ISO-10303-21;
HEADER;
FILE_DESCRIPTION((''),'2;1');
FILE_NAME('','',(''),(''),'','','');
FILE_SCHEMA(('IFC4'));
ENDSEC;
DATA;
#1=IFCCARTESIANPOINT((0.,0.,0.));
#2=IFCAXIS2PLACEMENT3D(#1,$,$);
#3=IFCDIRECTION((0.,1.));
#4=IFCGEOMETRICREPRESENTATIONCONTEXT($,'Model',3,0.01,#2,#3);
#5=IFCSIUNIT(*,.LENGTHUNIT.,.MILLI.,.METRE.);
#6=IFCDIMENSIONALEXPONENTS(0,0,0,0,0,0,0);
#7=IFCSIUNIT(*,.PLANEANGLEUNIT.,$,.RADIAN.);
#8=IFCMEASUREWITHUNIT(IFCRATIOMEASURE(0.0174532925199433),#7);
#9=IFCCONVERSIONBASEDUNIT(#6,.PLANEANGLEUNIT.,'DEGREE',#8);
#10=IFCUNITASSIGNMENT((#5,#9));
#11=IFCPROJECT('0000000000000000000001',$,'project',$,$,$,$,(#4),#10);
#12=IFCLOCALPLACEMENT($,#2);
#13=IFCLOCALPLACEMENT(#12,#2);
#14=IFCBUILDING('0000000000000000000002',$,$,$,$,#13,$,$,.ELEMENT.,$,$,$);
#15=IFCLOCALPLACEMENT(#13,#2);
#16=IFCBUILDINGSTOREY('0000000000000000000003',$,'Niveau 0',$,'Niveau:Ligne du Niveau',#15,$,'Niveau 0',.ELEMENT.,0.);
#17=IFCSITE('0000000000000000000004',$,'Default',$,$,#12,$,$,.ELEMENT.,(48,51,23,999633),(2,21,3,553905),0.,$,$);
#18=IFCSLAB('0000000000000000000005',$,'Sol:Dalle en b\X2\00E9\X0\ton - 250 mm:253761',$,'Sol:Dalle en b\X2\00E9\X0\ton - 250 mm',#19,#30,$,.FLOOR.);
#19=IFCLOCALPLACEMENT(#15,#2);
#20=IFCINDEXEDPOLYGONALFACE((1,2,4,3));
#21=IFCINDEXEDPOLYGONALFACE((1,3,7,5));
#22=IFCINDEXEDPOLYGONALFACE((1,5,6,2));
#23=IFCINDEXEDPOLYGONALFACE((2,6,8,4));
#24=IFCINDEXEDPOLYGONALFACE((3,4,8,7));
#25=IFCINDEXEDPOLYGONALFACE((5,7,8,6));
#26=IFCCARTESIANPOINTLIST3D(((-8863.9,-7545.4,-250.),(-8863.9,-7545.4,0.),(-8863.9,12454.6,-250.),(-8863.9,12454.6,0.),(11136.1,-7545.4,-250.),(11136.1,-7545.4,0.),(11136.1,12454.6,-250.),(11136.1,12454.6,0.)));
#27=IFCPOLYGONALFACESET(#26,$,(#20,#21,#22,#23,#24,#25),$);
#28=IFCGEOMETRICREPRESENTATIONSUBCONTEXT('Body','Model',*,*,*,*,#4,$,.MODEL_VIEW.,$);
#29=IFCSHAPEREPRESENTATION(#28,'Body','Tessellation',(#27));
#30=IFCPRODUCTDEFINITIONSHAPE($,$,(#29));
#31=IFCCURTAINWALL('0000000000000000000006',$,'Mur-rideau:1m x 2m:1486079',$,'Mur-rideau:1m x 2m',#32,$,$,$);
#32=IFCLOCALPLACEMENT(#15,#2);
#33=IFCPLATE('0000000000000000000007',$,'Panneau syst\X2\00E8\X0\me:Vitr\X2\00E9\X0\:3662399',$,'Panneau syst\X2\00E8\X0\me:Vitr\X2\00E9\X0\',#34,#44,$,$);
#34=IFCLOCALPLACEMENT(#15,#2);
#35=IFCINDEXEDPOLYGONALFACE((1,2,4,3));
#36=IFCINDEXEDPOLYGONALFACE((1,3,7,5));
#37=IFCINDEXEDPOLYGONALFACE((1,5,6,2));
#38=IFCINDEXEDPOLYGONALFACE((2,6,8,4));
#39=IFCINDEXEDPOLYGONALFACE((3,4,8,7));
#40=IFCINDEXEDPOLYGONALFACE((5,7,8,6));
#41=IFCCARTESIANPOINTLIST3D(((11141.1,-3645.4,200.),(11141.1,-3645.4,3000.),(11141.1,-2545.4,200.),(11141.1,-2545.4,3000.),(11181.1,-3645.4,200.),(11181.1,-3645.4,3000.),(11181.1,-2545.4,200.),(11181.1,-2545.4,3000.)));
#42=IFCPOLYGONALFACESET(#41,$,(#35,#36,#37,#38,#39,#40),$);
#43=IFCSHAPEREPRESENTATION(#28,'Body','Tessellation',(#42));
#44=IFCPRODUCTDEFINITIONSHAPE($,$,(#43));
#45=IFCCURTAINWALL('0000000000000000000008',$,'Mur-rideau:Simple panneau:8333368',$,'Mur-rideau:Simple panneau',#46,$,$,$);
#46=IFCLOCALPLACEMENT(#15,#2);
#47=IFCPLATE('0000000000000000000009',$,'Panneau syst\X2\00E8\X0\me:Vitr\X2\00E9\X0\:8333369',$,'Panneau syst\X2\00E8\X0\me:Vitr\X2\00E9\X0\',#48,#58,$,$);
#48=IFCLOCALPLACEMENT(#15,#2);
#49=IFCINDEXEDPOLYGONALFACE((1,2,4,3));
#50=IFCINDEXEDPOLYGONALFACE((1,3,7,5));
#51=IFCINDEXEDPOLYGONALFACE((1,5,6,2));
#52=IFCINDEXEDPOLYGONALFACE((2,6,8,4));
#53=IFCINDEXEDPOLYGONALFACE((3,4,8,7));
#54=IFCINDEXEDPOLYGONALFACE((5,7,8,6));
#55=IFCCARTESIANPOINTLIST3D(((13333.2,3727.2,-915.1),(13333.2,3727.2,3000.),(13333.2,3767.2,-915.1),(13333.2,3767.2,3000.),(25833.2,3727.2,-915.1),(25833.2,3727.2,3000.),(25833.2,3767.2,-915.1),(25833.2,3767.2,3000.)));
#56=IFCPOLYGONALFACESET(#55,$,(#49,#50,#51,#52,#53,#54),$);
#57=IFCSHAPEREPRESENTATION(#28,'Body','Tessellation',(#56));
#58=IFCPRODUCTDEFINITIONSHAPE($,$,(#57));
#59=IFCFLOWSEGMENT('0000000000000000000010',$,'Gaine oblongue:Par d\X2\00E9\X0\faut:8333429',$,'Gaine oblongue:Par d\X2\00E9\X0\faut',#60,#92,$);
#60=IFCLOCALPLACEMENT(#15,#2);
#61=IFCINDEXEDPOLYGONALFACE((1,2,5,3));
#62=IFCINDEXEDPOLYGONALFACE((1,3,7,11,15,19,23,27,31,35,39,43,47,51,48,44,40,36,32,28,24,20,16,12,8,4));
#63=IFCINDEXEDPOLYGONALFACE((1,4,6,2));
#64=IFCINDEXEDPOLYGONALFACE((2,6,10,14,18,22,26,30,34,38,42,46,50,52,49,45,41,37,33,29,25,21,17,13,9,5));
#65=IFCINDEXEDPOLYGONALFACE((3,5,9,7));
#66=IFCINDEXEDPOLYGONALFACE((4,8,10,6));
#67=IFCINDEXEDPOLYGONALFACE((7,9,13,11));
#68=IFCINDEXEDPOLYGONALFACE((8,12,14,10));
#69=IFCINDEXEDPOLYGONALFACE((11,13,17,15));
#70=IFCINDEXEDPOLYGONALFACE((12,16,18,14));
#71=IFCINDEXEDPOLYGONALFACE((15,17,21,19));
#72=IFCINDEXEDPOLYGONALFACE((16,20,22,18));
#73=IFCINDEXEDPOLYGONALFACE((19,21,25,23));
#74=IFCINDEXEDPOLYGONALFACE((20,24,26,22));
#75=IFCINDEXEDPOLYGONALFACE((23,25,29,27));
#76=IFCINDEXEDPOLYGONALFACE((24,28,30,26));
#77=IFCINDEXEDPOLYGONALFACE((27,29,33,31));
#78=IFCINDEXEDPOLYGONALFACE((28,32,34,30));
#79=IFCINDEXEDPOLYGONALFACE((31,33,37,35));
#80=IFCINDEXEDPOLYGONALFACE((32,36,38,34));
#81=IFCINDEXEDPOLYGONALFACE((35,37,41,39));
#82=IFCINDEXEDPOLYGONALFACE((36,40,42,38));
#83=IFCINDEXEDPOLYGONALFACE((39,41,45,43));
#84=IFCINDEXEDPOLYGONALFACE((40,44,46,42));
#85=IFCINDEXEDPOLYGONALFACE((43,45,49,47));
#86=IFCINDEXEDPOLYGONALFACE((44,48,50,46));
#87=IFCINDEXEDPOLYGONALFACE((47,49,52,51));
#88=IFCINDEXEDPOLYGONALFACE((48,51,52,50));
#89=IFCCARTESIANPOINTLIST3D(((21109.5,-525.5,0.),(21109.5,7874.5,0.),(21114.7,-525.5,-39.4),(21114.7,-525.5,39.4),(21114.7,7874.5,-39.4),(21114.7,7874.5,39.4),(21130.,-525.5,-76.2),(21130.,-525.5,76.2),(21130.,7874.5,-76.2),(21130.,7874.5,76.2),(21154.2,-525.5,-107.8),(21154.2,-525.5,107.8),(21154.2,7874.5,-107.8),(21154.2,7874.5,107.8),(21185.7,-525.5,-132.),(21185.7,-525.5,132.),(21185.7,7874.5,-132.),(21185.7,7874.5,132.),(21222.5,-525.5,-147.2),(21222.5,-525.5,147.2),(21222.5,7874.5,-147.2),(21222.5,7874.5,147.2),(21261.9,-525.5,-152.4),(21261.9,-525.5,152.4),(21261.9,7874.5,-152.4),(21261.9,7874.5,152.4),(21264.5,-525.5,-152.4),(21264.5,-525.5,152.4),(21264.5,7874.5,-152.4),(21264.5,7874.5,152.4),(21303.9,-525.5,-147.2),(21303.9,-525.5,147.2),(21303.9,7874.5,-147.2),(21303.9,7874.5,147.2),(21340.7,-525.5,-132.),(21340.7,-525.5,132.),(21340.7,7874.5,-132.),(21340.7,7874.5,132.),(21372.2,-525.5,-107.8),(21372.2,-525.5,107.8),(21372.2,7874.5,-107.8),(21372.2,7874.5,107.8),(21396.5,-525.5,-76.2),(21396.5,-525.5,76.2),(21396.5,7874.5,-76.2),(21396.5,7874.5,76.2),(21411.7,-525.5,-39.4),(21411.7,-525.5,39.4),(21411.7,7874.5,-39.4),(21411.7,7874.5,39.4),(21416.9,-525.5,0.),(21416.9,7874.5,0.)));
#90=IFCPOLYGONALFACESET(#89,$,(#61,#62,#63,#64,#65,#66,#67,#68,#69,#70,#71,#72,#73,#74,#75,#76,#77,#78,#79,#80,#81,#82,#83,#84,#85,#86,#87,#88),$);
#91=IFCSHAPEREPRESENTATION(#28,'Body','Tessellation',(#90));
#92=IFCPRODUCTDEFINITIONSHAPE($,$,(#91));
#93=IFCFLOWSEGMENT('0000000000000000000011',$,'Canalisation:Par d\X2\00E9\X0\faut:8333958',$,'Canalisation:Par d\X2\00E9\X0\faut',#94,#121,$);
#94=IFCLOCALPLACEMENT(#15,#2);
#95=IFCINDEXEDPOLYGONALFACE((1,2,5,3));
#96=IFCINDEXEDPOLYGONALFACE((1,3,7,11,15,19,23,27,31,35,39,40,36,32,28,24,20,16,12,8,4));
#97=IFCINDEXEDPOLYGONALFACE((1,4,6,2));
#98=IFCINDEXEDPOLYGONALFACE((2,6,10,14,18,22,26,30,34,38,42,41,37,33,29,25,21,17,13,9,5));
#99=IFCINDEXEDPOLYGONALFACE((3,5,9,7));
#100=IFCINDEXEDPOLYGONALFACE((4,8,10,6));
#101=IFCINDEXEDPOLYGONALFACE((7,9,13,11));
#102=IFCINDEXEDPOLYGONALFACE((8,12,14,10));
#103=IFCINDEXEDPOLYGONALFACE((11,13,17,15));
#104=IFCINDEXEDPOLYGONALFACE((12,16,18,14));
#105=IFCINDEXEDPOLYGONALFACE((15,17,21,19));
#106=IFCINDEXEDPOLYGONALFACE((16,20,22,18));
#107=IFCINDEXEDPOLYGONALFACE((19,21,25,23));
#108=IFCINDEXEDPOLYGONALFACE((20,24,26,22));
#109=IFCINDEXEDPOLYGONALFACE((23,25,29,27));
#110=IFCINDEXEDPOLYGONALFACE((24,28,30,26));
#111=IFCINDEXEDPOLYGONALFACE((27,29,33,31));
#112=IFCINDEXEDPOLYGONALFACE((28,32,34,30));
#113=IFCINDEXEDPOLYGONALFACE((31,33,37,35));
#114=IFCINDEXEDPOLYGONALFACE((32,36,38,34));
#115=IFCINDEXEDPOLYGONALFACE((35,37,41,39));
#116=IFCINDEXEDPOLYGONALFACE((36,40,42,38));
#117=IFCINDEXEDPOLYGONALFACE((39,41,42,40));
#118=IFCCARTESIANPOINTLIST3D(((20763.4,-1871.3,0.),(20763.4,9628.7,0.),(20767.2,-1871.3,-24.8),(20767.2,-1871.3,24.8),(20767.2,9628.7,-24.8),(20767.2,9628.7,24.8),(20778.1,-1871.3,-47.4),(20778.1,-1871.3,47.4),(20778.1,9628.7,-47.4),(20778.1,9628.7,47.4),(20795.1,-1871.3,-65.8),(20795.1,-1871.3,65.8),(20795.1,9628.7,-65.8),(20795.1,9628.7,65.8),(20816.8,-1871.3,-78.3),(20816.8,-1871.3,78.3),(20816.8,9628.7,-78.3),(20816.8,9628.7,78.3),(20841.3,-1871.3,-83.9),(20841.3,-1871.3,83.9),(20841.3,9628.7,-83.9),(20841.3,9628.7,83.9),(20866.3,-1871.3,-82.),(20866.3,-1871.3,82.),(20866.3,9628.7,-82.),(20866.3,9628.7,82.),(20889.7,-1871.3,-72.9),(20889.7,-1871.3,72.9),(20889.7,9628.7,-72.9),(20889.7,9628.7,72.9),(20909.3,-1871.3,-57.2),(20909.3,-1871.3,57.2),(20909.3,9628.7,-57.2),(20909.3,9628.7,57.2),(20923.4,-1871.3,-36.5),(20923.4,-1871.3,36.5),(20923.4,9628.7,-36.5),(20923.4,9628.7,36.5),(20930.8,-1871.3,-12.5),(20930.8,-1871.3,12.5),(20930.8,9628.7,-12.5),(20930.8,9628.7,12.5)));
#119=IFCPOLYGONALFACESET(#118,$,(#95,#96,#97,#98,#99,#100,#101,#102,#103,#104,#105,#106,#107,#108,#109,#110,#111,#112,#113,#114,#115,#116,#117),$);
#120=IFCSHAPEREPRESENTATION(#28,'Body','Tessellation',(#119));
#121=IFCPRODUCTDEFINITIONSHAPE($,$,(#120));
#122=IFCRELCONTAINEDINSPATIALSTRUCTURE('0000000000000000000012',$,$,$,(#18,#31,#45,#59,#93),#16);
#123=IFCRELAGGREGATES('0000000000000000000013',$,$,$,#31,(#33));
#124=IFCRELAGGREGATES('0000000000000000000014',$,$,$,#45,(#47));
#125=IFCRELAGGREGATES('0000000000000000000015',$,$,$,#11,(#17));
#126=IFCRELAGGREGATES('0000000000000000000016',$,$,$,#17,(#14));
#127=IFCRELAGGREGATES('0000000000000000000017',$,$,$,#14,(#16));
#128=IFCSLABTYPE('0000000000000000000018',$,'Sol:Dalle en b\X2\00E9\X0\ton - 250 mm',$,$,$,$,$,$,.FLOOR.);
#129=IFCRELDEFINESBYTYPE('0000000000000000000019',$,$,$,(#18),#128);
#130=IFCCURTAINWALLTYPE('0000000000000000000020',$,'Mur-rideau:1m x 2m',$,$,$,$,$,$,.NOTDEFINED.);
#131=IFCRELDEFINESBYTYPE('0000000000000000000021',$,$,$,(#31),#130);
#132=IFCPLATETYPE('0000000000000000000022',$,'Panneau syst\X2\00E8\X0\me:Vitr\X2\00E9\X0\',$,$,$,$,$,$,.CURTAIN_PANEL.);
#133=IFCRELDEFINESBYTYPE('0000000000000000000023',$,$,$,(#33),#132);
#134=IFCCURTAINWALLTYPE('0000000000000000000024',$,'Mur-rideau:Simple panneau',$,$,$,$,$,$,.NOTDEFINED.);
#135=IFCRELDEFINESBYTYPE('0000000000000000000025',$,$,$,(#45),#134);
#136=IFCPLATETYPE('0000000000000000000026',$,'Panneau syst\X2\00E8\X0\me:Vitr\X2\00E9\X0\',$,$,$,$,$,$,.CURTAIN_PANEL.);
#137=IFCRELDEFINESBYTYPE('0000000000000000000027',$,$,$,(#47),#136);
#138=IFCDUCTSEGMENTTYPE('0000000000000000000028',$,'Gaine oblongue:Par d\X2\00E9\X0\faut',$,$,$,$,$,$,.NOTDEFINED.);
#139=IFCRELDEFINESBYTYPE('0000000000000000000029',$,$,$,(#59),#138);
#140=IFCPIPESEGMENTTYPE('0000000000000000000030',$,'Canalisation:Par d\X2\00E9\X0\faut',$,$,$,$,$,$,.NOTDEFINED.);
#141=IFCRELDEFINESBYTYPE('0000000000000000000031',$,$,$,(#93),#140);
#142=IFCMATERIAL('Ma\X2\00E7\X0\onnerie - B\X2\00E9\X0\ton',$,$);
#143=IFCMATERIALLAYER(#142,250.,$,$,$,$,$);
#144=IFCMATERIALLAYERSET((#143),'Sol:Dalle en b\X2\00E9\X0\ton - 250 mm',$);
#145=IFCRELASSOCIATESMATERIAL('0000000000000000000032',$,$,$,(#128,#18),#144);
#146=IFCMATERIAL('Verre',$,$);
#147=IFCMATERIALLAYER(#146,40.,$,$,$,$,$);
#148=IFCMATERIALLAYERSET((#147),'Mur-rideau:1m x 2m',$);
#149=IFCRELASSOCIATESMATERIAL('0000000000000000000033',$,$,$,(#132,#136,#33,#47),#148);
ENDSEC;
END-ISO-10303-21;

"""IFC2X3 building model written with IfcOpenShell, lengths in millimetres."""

from ifc_helpers import new_model, entity, si_unit, converted_unit, direction, frame, frame_2d, origin, origin_2d_with_axis, place, context, subcontext, project, spatial, polyline, circle_curve, parameter, trimmed, segment, composite_curve, rectangle, circle, outline, extrude, source, transform, mapped, material, layer, layer_set, layer_usage, type_object, type_shapes, element, aggregate, save


model = new_model("IFC2X3")

# Units and contexts
model_context = context("Model", 3, precision=0.01, world=origin(), true_north=direction((0.0, 1.0)))
body_context = subcontext(model_context, "Body", "Model", "MODEL_VIEW")
ifc_project = project(units=[si_unit("LENGTHUNIT", "METRE", prefix="MILLI"), converted_unit("PLANEANGLEUNIT", "DEGREE", entity("IfcRatioMeasure", 0.0174532925199433), si_unit("PLANEANGLEUNIT", "RADIAN"), dimensions=[0, 0, 0, 0, 0, 0, 0])], contexts=[model_context])

# Site, building, storey
site_placement = place(None, origin())
site = spatial("IfcSite", under=ifc_project, at=site_placement, Name="Default", CompositionType="ELEMENT", RefLatitude=(48, 51, 23, 999633), RefLongitude=(2, 21, 3, 553905), RefElevation=0.0)
building_placement = place(site_placement, origin())
building = spatial("IfcBuilding", under=site, at=building_placement, CompositionType="ELEMENT")
storey_placement = place(building_placement, origin())
storey = spatial("IfcBuildingStorey", under=building, at=storey_placement, Name="Niveau 0", ObjectType="Niveau:Ligne du Niveau", LongName="Niveau 0", CompositionType="ELEMENT", Elevation=0.0)

# Slab
ifc_material_1 = material(Name="Maçonnerie - Béton")
ifc_layer_1 = layer(ifc_material_1, 250.0)
ifc_layer_set_1 = layer_set([ifc_layer_1], Name="Sol:Dalle en béton - 250 mm")
ifc_layer_usage_1 = layer_usage(ifc_layer_set_1, "AXIS3", "POSITIVE", 0.0)
slab_type = type_object("IfcSlabType", Name="Sol:Dalle en béton - 250 mm", PredefinedType="FLOOR", material=ifc_layer_set_1)
slab_placement = place(storey_placement, origin())
element("IfcSlab", 1, at=slab_placement, inside=storey, type_object=slab_type, material=ifc_layer_usage_1, Name="Sol:Dalle en béton - 250 mm:253761", ObjectType="Sol:Dalle en béton - 250 mm", PredefinedType="FLOOR", context=body_context, shape_type="SweptSolid", body=[
    extrude(rectangle(XDim=20000.0, YDim=20000.0, at=origin_2d_with_axis()), frame((1136.1, 2454.6, 0.0), z_axis=(0.0, 0.0, -1.0), x_axis=(0.0, 1.0, 0.0)), (0.0, 0.0, 1.0), 250.0),
])

# Curtain wall, plate
curtain_wall_type_1 = type_object("IfcCurtainWallType", Name="Mur-rideau:1m x 2m", PredefinedType="NOTDEFINED")
ifc_material_2 = material(Name="Verre")
ifc_layer_2 = layer(ifc_material_2, 40.0)
ifc_layer_set_2 = layer_set([ifc_layer_2], Name="Mur-rideau:1m x 2m")
curtain_wall_1_placement = place(storey_placement, origin())
curtain_wall_1 = element("IfcCurtainWall", 2, at=curtain_wall_1_placement, inside=storey, type_object=curtain_wall_type_1, Name="Mur-rideau:1m x 2m:1486079", ObjectType="Mur-rideau:1m x 2m")
ifc_layer_usage_2 = layer_usage(ifc_layer_set_2, "AXIS3", "POSITIVE", 0.1)
plate_type_1 = type_object("IfcPlateType", Name="Panneau système:Vitré", PredefinedType="CURTAIN_PANEL", material=ifc_layer_set_2)
shared_shape_1 = source(origin(), body_context, "Body", "SweptSolid", [
    extrude(rectangle(XDim=40.0, YDim=1100.0, at=frame_2d((0.0, 0.0), x_axis=(1.0, 0.0))), frame((0.0, 25.0, 0.0), z_axis=(0.0, 0.0, 1.0), x_axis=(0.0, 1.0, 0.0)), (0.0, 0.0, 1.0), 2800.0),
])
type_shapes(plate_type_1, [shared_shape_1])
plate_1_placement = place(curtain_wall_1_placement, frame((11136.1, -3095.4, 200.0), z_axis=(0.0, 0.0, 1.0), x_axis=(0.0, -1.0, 0.0)))
plate_1 = element("IfcPlate", 3, at=plate_1_placement, type_object=plate_type_1, material=ifc_layer_usage_2, Name="Panneau système:Vitré:3662399", ObjectType="Panneau système:Vitré", context=body_context, shape_type="MappedRepresentation", body=[
    mapped(shared_shape_1, transform((0.0, 0.0, 0.0), scale=1.0)),
])
aggregate(curtain_wall_1, [plate_1])

# Curtain wall, plate
curtain_wall_type_2 = type_object("IfcCurtainWallType", Name="Mur-rideau:Simple panneau", PredefinedType="NOTDEFINED")
curtain_wall_2_placement = place(storey_placement, origin())
curtain_wall_2 = element("IfcCurtainWall", 4, at=curtain_wall_2_placement, inside=storey, type_object=curtain_wall_type_2, Name="Mur-rideau:Simple panneau:8333368", ObjectType="Mur-rideau:Simple panneau")
ifc_layer_usage_3 = layer_usage(ifc_layer_set_2, "AXIS3", "POSITIVE", 0.1)
plate_type_2 = type_object("IfcPlateType", Name="Panneau système:Vitré", PredefinedType="CURTAIN_PANEL", material=ifc_layer_set_2)
shared_shape_2 = source(origin(), body_context, "Body", "SweptSolid", [
    extrude(rectangle(XDim=40.0, YDim=12500.0, at=frame_2d((0.0, 0.0), x_axis=(1.0, 0.0))), frame((0.0, 25.0, 0.0), z_axis=(0.0, 0.0, 1.0), x_axis=(0.0, 1.0, 0.0)), (0.0, 0.0, 1.0), 3915.1),
])
type_shapes(plate_type_2, [shared_shape_2])
plate_2_placement = place(curtain_wall_2_placement, frame((19583.2, 3772.2, -915.1), z_axis=(0.0, 0.0, 1.0), x_axis=(-1.0, 0.0, 0.0)))
plate_2 = element("IfcPlate", 5, at=plate_2_placement, type_object=plate_type_2, material=ifc_layer_usage_3, Name="Panneau système:Vitré:8333369", ObjectType="Panneau système:Vitré", context=body_context, shape_type="MappedRepresentation", body=[
    mapped(shared_shape_2, transform((0.0, 0.0, 0.0), scale=1.0)),
])
aggregate(curtain_wall_2, [plate_2])

# Flow segments
duct_segment_type = type_object("IfcDuctSegmentType", Name="Gaine oblongue:Par défaut", PredefinedType="NOTDEFINED")
flow_segment_1_placement = place(storey_placement, origin())
element("IfcFlowSegment", 6, at=flow_segment_1_placement, inside=storey, type_object=duct_segment_type, Name="Gaine oblongue:Par défaut:8333429", ObjectType="Gaine oblongue:Par défaut", context=body_context, shape_type="SweptSolid", body=[
    extrude(outline(composite_curve([segment(polyline([(-1.3, -152.4), (1.3, -152.4)]), True, "CONTINUOUS"), segment(trimmed(circle_curve(frame_2d((1.3, 0.0), x_axis=(-1.0, 0.0)), 152.4), [parameter(90.0)], [parameter(180.0)], True, "PARAMETER"), True, "CONTINUOUS"), segment(trimmed(circle_curve(frame_2d((1.3, 0.0), x_axis=(-1.0, 0.0)), 152.4), [parameter(180.0)], [parameter(270.0)], True, "PARAMETER"), True, "CONTINUOUS"), segment(polyline([(1.3, 152.4), (-1.3, 152.4)]), True, "CONTINUOUS"), segment(trimmed(circle_curve(frame_2d((-1.3, 0.0), x_axis=(-1.0, 0.0)), 152.4), [parameter(270.0)], [parameter(0.0)], True, "PARAMETER"), True, "CONTINUOUS"), segment(trimmed(circle_curve(frame_2d((-1.3, 0.0), x_axis=(-1.0, 0.0)), 152.4), [parameter(0.0)], [parameter(90.0)], True, "PARAMETER"), True, "CONTINUOUS")], self_intersect=False)), frame((21263.2, -525.5, 0.0), z_axis=(0.0, 1.0, 0.0), x_axis=(1.0, 0.0, 0.0)), (0.0, 0.0, 1.0), 8400.0),
])
pipe_segment_type = type_object("IfcPipeSegmentType", Name="Canalisation:Par défaut", PredefinedType="NOTDEFINED")
flow_segment_2_placement = place(storey_placement, origin())
element("IfcFlowSegment", 7, at=flow_segment_2_placement, inside=storey, type_object=pipe_segment_type, Name="Canalisation:Par défaut:8333958", ObjectType="Canalisation:Par défaut", context=body_context, shape_type="SweptSolid", body=[
    extrude(circle(Radius=84.1, at=frame_2d((0.0, 0.0), x_axis=(1.0, 0.0))), frame((20847.6, -1871.3, 0.0), z_axis=(0.0, 1.0, 0.0), x_axis=(-1.0, 0.0, 0.0)), (0.0, 0.0, 1.0), 11500.0),
])

save(model, "model.ifc")
